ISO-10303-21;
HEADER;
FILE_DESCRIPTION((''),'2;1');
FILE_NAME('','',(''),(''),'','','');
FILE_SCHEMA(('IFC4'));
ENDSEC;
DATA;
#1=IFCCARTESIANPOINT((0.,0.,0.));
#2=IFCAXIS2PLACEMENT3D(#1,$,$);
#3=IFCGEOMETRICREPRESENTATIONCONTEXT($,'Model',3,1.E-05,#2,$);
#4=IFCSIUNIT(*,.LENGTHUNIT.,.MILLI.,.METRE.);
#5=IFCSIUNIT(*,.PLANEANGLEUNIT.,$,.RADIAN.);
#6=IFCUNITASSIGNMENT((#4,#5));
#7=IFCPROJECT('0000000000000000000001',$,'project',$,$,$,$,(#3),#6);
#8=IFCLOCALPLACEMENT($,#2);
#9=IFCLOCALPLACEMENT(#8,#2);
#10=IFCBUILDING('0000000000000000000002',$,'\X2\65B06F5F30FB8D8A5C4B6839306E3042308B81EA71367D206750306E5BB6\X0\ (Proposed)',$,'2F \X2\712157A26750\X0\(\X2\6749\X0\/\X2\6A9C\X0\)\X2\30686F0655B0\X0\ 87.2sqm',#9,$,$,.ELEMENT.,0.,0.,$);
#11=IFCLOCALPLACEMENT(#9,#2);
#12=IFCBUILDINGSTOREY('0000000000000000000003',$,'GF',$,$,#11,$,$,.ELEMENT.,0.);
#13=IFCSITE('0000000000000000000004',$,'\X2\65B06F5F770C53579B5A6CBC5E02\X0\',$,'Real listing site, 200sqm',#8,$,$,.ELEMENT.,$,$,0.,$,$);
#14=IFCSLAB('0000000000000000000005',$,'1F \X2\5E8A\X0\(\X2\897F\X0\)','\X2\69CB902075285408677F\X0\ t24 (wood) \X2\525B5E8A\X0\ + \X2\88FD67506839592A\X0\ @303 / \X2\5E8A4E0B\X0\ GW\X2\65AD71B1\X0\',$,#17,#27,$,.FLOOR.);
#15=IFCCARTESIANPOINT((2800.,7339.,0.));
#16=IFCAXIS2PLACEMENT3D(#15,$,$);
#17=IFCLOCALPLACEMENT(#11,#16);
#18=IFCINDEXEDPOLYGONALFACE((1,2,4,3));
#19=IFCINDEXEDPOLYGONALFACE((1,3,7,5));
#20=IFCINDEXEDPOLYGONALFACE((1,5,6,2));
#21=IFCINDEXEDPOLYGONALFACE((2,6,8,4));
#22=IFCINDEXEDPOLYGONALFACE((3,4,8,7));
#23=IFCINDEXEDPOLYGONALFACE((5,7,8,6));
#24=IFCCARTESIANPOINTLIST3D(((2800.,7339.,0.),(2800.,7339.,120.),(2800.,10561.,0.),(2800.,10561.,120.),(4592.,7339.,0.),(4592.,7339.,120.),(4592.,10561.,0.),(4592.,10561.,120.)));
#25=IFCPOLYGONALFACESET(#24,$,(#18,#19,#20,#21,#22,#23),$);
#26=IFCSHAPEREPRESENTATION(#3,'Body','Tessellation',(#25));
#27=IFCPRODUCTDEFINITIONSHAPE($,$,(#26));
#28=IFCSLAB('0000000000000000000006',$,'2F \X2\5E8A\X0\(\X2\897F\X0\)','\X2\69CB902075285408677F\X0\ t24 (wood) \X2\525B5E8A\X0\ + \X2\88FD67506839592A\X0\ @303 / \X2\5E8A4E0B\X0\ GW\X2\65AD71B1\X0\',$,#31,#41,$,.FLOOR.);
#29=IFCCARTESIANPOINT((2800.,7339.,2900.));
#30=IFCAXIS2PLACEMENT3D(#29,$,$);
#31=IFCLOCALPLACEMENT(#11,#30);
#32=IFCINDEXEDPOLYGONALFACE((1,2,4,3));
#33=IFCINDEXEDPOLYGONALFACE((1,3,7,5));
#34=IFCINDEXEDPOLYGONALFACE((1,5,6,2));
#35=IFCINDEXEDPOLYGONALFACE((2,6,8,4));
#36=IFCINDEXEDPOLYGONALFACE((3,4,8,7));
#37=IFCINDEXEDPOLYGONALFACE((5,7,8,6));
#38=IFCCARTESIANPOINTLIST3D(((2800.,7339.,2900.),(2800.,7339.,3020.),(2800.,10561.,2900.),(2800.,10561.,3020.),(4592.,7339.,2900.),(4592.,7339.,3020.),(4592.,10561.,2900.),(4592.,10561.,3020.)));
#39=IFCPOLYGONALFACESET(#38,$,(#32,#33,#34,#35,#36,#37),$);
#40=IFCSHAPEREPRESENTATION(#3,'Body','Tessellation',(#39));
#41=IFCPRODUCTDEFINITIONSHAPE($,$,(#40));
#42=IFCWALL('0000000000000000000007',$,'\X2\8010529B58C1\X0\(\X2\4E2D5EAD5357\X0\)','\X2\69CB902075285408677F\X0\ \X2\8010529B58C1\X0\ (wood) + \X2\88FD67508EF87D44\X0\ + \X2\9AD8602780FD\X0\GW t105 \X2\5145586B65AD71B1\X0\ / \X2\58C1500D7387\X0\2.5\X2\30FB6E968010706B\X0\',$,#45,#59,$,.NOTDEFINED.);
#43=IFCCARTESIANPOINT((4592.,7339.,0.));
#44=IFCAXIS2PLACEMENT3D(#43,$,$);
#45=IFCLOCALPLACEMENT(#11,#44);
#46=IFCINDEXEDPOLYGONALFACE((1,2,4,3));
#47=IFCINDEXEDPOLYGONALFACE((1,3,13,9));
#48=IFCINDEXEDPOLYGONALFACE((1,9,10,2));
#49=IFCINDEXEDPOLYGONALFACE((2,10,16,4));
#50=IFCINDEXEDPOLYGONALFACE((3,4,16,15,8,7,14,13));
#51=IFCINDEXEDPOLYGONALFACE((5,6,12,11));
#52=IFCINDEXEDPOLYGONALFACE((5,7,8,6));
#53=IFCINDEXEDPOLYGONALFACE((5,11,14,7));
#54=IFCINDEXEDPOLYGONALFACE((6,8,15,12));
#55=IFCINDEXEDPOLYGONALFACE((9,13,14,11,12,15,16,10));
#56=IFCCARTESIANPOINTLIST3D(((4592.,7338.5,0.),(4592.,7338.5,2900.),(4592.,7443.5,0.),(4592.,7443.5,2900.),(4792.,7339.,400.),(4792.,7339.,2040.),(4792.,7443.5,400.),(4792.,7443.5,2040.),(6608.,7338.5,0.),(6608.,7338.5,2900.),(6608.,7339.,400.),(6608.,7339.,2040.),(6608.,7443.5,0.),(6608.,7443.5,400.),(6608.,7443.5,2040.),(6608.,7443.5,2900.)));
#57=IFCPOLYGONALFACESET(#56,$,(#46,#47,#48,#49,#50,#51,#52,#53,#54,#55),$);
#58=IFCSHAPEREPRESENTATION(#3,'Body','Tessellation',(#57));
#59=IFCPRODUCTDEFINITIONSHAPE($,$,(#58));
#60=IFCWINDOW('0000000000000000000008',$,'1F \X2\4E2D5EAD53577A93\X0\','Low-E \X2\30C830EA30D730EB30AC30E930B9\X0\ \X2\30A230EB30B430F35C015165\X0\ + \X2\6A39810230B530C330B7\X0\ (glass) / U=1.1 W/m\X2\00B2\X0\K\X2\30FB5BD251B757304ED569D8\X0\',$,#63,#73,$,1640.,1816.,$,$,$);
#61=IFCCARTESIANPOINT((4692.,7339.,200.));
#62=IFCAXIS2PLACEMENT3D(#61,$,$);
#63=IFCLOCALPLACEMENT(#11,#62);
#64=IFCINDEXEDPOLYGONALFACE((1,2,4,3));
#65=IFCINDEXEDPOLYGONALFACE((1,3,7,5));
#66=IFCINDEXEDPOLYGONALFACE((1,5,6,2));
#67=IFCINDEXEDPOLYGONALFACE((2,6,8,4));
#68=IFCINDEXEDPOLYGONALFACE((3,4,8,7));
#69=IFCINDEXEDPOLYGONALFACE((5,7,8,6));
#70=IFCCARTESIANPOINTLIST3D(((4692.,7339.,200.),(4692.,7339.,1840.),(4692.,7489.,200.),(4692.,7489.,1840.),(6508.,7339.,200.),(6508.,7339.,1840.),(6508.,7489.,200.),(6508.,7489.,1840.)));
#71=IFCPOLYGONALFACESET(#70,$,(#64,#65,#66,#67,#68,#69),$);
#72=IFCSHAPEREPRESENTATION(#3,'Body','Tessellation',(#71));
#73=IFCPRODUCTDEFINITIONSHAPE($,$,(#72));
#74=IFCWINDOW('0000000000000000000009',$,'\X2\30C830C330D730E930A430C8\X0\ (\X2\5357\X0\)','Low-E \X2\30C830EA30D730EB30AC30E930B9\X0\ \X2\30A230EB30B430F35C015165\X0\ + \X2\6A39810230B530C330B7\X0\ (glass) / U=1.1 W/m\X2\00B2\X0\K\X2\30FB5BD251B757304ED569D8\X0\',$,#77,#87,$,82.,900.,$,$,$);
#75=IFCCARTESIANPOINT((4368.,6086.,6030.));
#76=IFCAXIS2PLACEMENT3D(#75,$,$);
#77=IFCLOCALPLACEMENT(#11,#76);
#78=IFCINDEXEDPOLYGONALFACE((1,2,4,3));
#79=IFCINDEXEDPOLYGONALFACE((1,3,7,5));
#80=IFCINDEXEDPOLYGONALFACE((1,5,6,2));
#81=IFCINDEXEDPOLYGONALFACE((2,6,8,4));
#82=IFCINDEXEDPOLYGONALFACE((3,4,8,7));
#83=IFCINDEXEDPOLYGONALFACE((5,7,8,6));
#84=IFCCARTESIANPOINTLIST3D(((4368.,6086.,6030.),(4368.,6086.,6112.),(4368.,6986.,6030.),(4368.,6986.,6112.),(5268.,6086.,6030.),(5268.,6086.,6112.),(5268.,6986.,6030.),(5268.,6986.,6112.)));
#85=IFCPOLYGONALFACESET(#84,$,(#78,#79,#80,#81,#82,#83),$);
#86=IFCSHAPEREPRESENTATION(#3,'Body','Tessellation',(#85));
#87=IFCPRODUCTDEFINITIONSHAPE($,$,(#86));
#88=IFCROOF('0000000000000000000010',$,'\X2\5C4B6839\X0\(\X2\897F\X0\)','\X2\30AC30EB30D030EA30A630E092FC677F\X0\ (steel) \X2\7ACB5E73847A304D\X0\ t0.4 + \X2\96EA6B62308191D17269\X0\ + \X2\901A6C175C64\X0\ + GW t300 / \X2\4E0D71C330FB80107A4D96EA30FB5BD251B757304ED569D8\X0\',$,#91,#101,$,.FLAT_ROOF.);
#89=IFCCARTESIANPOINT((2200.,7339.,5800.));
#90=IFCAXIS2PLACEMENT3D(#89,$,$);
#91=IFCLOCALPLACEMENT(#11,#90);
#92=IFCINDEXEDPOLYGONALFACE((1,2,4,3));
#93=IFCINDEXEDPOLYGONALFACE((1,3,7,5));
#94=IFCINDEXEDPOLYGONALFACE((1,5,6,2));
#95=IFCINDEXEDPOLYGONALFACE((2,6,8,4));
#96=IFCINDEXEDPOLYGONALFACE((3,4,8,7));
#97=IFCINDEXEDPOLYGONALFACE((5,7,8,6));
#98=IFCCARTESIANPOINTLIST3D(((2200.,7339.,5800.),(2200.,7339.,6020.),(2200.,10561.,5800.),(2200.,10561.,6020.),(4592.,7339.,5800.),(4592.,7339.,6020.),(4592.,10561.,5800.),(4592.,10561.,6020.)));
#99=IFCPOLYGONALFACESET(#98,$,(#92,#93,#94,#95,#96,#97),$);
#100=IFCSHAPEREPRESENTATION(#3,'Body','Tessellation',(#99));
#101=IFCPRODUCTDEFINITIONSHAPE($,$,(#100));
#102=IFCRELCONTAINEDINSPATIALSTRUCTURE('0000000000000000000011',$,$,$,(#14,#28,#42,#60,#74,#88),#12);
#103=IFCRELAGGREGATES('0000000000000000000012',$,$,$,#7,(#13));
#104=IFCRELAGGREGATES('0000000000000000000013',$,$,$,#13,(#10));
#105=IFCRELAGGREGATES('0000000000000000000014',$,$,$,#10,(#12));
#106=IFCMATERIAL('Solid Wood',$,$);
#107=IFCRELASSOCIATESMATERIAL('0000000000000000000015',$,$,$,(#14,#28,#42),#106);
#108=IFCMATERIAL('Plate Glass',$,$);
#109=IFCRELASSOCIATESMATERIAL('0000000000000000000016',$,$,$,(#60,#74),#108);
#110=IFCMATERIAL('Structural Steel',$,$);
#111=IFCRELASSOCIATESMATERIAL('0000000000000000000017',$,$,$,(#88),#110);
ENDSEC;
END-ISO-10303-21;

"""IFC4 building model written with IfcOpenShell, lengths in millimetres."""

from ifc_helpers import new_model, si_unit, frame, frame_2d, origin, place, context, project, spatial, rectangle, extrude, material, element, fill, save


model = new_model("IFC4")

# Units and contexts
model_context = context("Model", 3, precision=1e-05, world=origin())
ifc_project = project(units=[si_unit("LENGTHUNIT", "METRE", prefix="MILLI"), si_unit("PLANEANGLEUNIT", "RADIAN")], contexts=[model_context])

# Site, building, storey
site_placement = place(None, origin())
site = spatial("IfcSite", under=ifc_project, at=site_placement, Name="新潟県南魚沼市", ObjectType="Real listing site, 200sqm", CompositionType="ELEMENT", RefElevation=0.0)
building_placement = place(site_placement, origin())
building = spatial("IfcBuilding", under=site, at=building_placement, Name="新潟・越屋根のある自然素材の家 (Proposed)", ObjectType="2F 無垢材(杉/檜)と漆喰 87.2sqm", CompositionType="ELEMENT", ElevationOfRefHeight=0.0, ElevationOfTerrain=0.0)
storey_placement = place(building_placement, origin())
storey = spatial("IfcBuildingStorey", under=building, at=storey_placement, Name="GF", CompositionType="ELEMENT", Elevation=0.0)

# Shared definitions
ifc_material_1 = material(Name="Solid Wood")

# Slabs
slab_1_placement = place(storey_placement, frame((2800.0, 7339.0, 0.0)))
element("IfcSlab", 1, at=slab_1_placement, inside=storey, material=ifc_material_1, Name="1F 床(西)", Description="構造用合板 t24 (wood) 剛床 + 製材根太 @303 / 床下 GW断熱", PredefinedType="FLOOR", context=model_context, shape_type="SweptSolid", body=[
    extrude(rectangle(XDim=1792.0, YDim=3222.0, at=frame_2d((896.0, 1611.0))), frame((2800.0, 7339.0, 0.0)), (0.0, 0.0, 1.0), 120.0),
])
slab_2_placement = place(storey_placement, frame((2800.0, 7339.0, 2900.0)))
element("IfcSlab", 2, at=slab_2_placement, inside=storey, material=ifc_material_1, Name="2F 床(西)", Description="構造用合板 t24 (wood) 剛床 + 製材根太 @303 / 床下 GW断熱", PredefinedType="FLOOR", context=model_context, shape_type="SweptSolid", body=[
    extrude(rectangle(XDim=1792.0, YDim=3222.0, at=frame_2d((896.0, 1611.0))), frame((2800.0, 7339.0, 2900.0)), (0.0, 0.0, 1.0), 120.0),
])

# Wall, opening, window
wall_placement = place(storey_placement, frame((4592.0, 7339.0, 0.0)))
wall = element("IfcWall", 3, at=wall_placement, inside=storey, material=ifc_material_1, Name="耐力壁(中庭南)", Description="構造用合板 耐力壁 (wood) + 製材軸組 + 高性能GW t105 充填断熱 / 壁倍率2.5・準耐火", PredefinedType="NOTDEFINED", context=model_context, shape_type="SweptSolid", body=[
    extrude(rectangle(XDim=2016.0, YDim=105.0, at=frame_2d((1008.0, 52.0))), frame((4592.0, 7339.0, 0.0)), (0.0, 0.0, 1.0), 2900.0),
])
opening_placement = place(storey_placement, frame((4692.0, 7339.0, 200.0)))
opening = element("IfcOpeningElement", 4, at=opening_placement, cuts=wall, PredefinedType="NOTDEFINED", context=model_context, shape_type="SweptSolid", body=[
    extrude(rectangle(XDim=1816.0, YDim=150.0, at=frame_2d((908.0, 75.0))), frame((4692.0, 7339.0, 200.0)), (0.0, 0.0, 1.0), 1640.0),
])
ifc_material_2 = material(Name="Plate Glass")
window_1_placement = place(storey_placement, frame((4692.0, 7339.0, 200.0)))
window_1 = element("IfcWindow", 5, at=window_1_placement, inside=storey, material=ifc_material_2, Name="1F 中庭南窓", Description="Low-E トリプルガラス アルゴン封入 + 樹脂サッシ (glass) / U=1.1 W/m²K・寒冷地仕様", OverallHeight=1640.0, OverallWidth=1816.0, context=model_context, shape_type="SweptSolid", body=[
    extrude(rectangle(XDim=1816.0, YDim=150.0, at=frame_2d((908.0, 75.0))), frame((4692.0, 7339.0, 200.0)), (0.0, 0.0, 1.0), 1640.0),
])
fill(opening, window_1)

# Window
window_2_placement = place(storey_placement, frame((4368.0, 6086.0, 6030.0)))
element("IfcWindow", 6, at=window_2_placement, inside=storey, material=ifc_material_2, Name="トップライト (南)", Description="Low-E トリプルガラス アルゴン封入 + 樹脂サッシ (glass) / U=1.1 W/m²K・寒冷地仕様", OverallHeight=82.0, OverallWidth=900.0, context=model_context, shape_type="SweptSolid", body=[
    extrude(rectangle(XDim=900.0, YDim=900.0, at=frame_2d((450.0, 450.0))), frame((4368.0, 6086.0, 6030.0)), (0.0, 0.0, 1.0), 82.0),
])

# Roof
ifc_material_3 = material(Name="Structural Steel")
for number, where, name in (
    (7, (2200.0, 7339.0, 5800.0), "屋根(西)"),
):
    element("IfcRoof", number, at=place(storey_placement, frame(where)), inside=storey, material=ifc_material_3, Name=name, Description="ガルバリウム鋼板 (steel) 立平葺き t0.4 + 雪止め金物 + 通気層 + GW t300 / 不燃・耐積雪・寒冷地仕様", PredefinedType="FLAT_ROOF", context=model_context, shape_type="SweptSolid", body=[
        extrude(rectangle(XDim=2392.0, YDim=3222.0, at=frame_2d((1196.0, 1611.0))), frame((2200.0, 7339.0, 5800.0)), (0.0, 0.0, 1.0), 220.0),
    ])

save(model, "model.ifc")
